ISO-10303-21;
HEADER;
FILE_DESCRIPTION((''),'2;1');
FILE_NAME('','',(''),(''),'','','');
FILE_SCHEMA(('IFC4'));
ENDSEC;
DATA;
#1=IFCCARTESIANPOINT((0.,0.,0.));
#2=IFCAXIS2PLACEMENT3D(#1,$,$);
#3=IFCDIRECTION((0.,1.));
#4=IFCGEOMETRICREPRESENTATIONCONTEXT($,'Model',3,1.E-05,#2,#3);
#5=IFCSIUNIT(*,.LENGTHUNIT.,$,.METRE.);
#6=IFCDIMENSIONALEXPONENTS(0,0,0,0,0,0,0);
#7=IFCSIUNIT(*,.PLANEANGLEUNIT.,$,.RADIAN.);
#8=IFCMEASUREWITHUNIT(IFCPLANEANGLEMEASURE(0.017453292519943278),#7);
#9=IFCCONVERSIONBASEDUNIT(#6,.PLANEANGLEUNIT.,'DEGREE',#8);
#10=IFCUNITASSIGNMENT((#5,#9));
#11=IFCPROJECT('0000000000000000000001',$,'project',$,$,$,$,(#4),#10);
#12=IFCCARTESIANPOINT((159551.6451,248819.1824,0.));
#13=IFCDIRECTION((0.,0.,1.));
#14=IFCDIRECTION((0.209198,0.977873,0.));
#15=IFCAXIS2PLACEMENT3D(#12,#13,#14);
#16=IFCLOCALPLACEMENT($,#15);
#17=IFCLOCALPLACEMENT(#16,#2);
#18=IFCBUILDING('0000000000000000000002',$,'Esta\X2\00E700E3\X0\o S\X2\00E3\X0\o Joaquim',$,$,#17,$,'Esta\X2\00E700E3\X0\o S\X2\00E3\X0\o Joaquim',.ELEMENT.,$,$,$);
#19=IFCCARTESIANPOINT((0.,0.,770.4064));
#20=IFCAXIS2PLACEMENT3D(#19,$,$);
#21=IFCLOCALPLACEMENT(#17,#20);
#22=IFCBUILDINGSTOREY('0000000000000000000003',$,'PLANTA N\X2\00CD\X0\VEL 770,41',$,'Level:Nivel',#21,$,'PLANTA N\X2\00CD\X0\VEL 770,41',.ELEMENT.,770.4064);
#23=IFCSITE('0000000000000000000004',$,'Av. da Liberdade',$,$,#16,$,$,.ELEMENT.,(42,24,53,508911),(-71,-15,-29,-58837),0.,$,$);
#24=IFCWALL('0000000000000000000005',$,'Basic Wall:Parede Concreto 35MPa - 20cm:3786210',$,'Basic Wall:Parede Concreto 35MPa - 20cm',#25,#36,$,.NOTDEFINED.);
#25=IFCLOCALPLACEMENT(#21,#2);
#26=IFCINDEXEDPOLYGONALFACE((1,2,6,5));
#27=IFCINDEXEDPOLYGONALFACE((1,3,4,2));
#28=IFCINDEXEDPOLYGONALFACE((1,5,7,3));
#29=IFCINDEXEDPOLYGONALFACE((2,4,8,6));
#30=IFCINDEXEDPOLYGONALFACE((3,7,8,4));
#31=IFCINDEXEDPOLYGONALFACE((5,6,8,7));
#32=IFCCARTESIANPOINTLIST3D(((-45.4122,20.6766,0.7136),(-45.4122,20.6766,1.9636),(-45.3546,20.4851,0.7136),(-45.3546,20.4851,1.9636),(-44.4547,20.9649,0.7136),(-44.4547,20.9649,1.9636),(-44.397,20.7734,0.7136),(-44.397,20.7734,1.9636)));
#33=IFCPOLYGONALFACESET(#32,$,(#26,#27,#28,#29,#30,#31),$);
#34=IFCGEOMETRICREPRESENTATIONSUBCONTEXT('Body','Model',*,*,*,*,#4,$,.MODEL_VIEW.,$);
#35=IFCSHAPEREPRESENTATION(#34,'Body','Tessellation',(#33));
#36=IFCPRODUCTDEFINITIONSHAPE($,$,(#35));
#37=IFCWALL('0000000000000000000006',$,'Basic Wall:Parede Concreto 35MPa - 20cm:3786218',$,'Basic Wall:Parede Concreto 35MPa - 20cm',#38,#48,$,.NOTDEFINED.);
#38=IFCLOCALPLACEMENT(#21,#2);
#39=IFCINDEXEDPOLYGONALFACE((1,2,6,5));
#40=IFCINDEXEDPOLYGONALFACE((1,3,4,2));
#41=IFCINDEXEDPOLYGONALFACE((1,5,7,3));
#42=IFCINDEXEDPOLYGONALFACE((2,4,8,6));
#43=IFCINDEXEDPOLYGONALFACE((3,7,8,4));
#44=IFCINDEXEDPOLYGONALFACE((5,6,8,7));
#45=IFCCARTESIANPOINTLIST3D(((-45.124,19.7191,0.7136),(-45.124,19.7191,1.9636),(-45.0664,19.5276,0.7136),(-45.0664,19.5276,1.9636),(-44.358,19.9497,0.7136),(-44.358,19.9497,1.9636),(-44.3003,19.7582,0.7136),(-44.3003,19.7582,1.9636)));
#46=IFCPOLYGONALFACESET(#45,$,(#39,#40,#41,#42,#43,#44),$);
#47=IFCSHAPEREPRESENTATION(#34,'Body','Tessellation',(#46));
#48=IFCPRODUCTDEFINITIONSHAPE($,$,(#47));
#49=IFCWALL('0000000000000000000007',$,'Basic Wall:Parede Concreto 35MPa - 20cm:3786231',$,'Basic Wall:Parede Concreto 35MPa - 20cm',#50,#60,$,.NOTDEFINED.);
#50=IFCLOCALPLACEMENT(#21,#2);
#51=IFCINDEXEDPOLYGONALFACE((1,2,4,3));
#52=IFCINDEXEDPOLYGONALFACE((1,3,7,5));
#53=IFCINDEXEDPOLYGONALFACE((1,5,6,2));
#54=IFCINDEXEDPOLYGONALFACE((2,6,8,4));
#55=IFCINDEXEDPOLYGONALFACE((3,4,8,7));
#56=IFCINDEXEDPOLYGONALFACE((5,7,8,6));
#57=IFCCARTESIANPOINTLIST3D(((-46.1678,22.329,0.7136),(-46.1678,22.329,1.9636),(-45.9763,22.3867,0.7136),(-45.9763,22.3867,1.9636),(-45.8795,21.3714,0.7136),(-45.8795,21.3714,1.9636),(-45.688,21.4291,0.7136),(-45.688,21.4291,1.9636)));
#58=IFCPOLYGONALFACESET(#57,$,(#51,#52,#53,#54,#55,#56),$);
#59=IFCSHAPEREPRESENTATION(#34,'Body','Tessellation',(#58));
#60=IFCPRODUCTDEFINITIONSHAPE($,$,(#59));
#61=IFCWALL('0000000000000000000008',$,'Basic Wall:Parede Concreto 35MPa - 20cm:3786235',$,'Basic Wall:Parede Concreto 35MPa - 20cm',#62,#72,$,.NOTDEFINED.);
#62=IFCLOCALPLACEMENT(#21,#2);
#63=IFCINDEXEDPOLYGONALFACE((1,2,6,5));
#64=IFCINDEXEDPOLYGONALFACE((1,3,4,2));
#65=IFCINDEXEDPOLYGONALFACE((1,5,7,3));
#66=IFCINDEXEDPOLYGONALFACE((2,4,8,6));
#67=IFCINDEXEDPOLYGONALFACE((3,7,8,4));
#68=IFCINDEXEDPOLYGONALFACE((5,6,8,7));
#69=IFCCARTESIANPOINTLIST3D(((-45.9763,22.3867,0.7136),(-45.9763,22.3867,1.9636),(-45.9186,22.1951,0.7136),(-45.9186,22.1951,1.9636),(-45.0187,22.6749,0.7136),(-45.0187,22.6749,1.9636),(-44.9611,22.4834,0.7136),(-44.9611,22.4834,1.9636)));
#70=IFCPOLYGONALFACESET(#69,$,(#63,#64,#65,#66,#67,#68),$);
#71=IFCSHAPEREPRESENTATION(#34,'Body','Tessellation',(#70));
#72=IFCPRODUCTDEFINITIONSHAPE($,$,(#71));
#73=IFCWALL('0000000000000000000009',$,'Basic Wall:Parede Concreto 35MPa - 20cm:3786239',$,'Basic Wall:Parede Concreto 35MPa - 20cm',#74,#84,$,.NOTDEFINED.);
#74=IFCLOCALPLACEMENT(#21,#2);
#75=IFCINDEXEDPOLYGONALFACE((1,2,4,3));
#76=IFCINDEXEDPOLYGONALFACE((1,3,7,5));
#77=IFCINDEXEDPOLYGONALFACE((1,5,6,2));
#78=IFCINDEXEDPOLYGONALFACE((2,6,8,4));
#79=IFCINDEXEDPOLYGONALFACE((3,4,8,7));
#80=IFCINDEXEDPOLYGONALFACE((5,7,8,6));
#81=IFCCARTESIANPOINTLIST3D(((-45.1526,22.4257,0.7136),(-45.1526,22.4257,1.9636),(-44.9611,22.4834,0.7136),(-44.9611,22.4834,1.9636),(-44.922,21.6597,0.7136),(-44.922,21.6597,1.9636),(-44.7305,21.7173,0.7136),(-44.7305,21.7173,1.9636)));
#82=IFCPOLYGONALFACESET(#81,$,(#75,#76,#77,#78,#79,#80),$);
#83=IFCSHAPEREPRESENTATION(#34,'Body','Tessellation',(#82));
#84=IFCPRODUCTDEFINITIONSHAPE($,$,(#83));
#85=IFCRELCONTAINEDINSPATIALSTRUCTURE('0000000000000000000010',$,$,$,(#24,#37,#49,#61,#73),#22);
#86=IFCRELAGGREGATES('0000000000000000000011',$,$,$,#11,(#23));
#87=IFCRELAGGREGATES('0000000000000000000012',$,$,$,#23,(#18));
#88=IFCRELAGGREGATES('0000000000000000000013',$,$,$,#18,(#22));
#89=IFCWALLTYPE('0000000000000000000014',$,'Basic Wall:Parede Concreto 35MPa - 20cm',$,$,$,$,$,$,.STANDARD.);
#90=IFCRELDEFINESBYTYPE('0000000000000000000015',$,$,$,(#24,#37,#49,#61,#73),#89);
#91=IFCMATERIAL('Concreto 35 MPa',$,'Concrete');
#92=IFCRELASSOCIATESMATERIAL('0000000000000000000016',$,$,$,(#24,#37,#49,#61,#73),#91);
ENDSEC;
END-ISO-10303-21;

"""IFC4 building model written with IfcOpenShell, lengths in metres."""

from ifc_helpers import new_model, entity, si_unit, converted_unit, direction, frame, origin, place, context, subcontext, project, spatial, indexed_curve, outline, extrude, material, type_object, element, save


model = new_model("IFC4")

# Units and contexts
model_context = context("Model", 3, precision=1e-05, world=origin(), true_north=direction((0.0, 1.0)))
body_context = subcontext(model_context, "Body", "Model", "MODEL_VIEW")
ifc_project = project(units=[si_unit("LENGTHUNIT", "METRE"), converted_unit("PLANEANGLEUNIT", "DEGREE", entity("IfcPlaneAngleMeasure", 0.017453292519943278), si_unit("PLANEANGLEUNIT", "RADIAN"), dimensions=[0, 0, 0, 0, 0, 0, 0])], contexts=[model_context])

# Site, building, storey
site_placement = place(None, frame((159551.6451, 248819.1824, 0.0), z_axis=(0.0, 0.0, 1.0), x_axis=(0.209198, 0.977873, 0.0)))
site = spatial("IfcSite", under=ifc_project, at=site_placement, Name="Av. da Liberdade", CompositionType="ELEMENT", RefLatitude=(42, 24, 53, 508911), RefLongitude=(-71, -15, -29, -58837), RefElevation=0.0)
building_placement = place(site_placement, origin())
building = spatial("IfcBuilding", under=site, at=building_placement, Name="Estação São Joaquim", LongName="Estação São Joaquim", CompositionType="ELEMENT")
storey_placement = place(building_placement, frame((0.0, 0.0, 770.4064)))
storey = spatial("IfcBuildingStorey", under=building, at=storey_placement, Name="PLANTA NÍVEL 770,41", ObjectType="Level:Nivel", LongName="PLANTA NÍVEL 770,41", CompositionType="ELEMENT", Elevation=770.4064)

# Walls
ifc_material = material(Name="Concreto 35 MPa", Category="Concrete")
wall_type = type_object("IfcWallType", Name="Basic Wall:Parede Concreto 35MPa - 20cm", PredefinedType="STANDARD")
wall_1_placement = place(storey_placement, frame((-45.3834, 20.5809, 0.7136), z_axis=(0.0, 0.0, 1.0), x_axis=(0.95756, 0.288234, 0.0)))
element("IfcWall", 1, at=wall_1_placement, inside=storey, type_object=wall_type, material=ifc_material, Name="Basic Wall:Parede Concreto 35MPa - 20cm:3786210", ObjectType="Basic Wall:Parede Concreto 35MPa - 20cm", PredefinedType="NOTDEFINED", context=body_context, shape_type="SweptSolid", body=[
    extrude(outline(indexed_curve([(1.0, 0.1), (0.0, 0.1), (0.0, -0.1), (1.0, -0.1), (1.0, 0.1)], self_intersect=False)), origin(), (0.0, 0.0, 1.0), 1.25),
])
wall_2_placement = place(storey_placement, frame((-44.3291, 19.8539, 0.7136), z_axis=(0.0, 0.0, 1.0), x_axis=(-0.95756, -0.288234, 0.0)))
element("IfcWall", 2, at=wall_2_placement, inside=storey, type_object=wall_type, material=ifc_material, Name="Basic Wall:Parede Concreto 35MPa - 20cm:3786218", ObjectType="Basic Wall:Parede Concreto 35MPa - 20cm", PredefinedType="NOTDEFINED", context=body_context, shape_type="SweptSolid", body=[
    extrude(outline(indexed_curve([(0.8, 0.1), (0.0, 0.1), (0.0, -0.1), (0.8, -0.1), (0.8, 0.1)], self_intersect=False)), origin(), (0.0, 0.0, 1.0), 1.25),
])
wall_3_placement = place(storey_placement, frame((-45.7838, 21.4003, 0.7136), z_axis=(0.0, 0.0, 1.0), x_axis=(-0.288234, 0.95756, 0.0)))
element("IfcWall", 3, at=wall_3_placement, inside=storey, type_object=wall_type, material=ifc_material, Name="Basic Wall:Parede Concreto 35MPa - 20cm:3786231", ObjectType="Basic Wall:Parede Concreto 35MPa - 20cm", PredefinedType="NOTDEFINED", context=body_context, shape_type="SweptSolid", body=[
    extrude(outline(indexed_curve([(1.0, 0.1), (0.0, 0.1), (0.0, -0.1), (1.0, -0.1), (1.0, 0.1)], self_intersect=False)), origin(), (0.0, 0.0, 1.0), 1.25),
])
wall_4_placement = place(storey_placement, frame((-45.9474, 22.2909, 0.7136), z_axis=(0.0, 0.0, 1.0), x_axis=(0.95756, 0.288234, 0.0)))
element("IfcWall", 4, at=wall_4_placement, inside=storey, type_object=wall_type, material=ifc_material, Name="Basic Wall:Parede Concreto 35MPa - 20cm:3786235", ObjectType="Basic Wall:Parede Concreto 35MPa - 20cm", PredefinedType="NOTDEFINED", context=body_context, shape_type="SweptSolid", body=[
    extrude(outline(indexed_curve([(1.0, 0.1), (0.0, 0.1), (0.0, -0.1), (1.0, -0.1), (1.0, 0.1)], self_intersect=False)), origin(), (0.0, 0.0, 1.0), 1.25),
])
wall_5_placement = place(storey_placement, frame((-45.0568, 22.4545, 0.7136), z_axis=(0.0, 0.0, 1.0), x_axis=(0.288234, -0.95756, 0.0)))
element("IfcWall", 5, at=wall_5_placement, inside=storey, type_object=wall_type, material=ifc_material, Name="Basic Wall:Parede Concreto 35MPa - 20cm:3786239", ObjectType="Basic Wall:Parede Concreto 35MPa - 20cm", PredefinedType="NOTDEFINED", context=body_context, shape_type="SweptSolid", body=[
    extrude(outline(indexed_curve([(0.8, 0.1), (0.0, 0.1), (0.0, -0.1), (0.8, -0.1), (0.8, 0.1)], self_intersect=False)), origin(), (0.0, 0.0, 1.0), 1.25),
])

save(model, "model.ifc")
